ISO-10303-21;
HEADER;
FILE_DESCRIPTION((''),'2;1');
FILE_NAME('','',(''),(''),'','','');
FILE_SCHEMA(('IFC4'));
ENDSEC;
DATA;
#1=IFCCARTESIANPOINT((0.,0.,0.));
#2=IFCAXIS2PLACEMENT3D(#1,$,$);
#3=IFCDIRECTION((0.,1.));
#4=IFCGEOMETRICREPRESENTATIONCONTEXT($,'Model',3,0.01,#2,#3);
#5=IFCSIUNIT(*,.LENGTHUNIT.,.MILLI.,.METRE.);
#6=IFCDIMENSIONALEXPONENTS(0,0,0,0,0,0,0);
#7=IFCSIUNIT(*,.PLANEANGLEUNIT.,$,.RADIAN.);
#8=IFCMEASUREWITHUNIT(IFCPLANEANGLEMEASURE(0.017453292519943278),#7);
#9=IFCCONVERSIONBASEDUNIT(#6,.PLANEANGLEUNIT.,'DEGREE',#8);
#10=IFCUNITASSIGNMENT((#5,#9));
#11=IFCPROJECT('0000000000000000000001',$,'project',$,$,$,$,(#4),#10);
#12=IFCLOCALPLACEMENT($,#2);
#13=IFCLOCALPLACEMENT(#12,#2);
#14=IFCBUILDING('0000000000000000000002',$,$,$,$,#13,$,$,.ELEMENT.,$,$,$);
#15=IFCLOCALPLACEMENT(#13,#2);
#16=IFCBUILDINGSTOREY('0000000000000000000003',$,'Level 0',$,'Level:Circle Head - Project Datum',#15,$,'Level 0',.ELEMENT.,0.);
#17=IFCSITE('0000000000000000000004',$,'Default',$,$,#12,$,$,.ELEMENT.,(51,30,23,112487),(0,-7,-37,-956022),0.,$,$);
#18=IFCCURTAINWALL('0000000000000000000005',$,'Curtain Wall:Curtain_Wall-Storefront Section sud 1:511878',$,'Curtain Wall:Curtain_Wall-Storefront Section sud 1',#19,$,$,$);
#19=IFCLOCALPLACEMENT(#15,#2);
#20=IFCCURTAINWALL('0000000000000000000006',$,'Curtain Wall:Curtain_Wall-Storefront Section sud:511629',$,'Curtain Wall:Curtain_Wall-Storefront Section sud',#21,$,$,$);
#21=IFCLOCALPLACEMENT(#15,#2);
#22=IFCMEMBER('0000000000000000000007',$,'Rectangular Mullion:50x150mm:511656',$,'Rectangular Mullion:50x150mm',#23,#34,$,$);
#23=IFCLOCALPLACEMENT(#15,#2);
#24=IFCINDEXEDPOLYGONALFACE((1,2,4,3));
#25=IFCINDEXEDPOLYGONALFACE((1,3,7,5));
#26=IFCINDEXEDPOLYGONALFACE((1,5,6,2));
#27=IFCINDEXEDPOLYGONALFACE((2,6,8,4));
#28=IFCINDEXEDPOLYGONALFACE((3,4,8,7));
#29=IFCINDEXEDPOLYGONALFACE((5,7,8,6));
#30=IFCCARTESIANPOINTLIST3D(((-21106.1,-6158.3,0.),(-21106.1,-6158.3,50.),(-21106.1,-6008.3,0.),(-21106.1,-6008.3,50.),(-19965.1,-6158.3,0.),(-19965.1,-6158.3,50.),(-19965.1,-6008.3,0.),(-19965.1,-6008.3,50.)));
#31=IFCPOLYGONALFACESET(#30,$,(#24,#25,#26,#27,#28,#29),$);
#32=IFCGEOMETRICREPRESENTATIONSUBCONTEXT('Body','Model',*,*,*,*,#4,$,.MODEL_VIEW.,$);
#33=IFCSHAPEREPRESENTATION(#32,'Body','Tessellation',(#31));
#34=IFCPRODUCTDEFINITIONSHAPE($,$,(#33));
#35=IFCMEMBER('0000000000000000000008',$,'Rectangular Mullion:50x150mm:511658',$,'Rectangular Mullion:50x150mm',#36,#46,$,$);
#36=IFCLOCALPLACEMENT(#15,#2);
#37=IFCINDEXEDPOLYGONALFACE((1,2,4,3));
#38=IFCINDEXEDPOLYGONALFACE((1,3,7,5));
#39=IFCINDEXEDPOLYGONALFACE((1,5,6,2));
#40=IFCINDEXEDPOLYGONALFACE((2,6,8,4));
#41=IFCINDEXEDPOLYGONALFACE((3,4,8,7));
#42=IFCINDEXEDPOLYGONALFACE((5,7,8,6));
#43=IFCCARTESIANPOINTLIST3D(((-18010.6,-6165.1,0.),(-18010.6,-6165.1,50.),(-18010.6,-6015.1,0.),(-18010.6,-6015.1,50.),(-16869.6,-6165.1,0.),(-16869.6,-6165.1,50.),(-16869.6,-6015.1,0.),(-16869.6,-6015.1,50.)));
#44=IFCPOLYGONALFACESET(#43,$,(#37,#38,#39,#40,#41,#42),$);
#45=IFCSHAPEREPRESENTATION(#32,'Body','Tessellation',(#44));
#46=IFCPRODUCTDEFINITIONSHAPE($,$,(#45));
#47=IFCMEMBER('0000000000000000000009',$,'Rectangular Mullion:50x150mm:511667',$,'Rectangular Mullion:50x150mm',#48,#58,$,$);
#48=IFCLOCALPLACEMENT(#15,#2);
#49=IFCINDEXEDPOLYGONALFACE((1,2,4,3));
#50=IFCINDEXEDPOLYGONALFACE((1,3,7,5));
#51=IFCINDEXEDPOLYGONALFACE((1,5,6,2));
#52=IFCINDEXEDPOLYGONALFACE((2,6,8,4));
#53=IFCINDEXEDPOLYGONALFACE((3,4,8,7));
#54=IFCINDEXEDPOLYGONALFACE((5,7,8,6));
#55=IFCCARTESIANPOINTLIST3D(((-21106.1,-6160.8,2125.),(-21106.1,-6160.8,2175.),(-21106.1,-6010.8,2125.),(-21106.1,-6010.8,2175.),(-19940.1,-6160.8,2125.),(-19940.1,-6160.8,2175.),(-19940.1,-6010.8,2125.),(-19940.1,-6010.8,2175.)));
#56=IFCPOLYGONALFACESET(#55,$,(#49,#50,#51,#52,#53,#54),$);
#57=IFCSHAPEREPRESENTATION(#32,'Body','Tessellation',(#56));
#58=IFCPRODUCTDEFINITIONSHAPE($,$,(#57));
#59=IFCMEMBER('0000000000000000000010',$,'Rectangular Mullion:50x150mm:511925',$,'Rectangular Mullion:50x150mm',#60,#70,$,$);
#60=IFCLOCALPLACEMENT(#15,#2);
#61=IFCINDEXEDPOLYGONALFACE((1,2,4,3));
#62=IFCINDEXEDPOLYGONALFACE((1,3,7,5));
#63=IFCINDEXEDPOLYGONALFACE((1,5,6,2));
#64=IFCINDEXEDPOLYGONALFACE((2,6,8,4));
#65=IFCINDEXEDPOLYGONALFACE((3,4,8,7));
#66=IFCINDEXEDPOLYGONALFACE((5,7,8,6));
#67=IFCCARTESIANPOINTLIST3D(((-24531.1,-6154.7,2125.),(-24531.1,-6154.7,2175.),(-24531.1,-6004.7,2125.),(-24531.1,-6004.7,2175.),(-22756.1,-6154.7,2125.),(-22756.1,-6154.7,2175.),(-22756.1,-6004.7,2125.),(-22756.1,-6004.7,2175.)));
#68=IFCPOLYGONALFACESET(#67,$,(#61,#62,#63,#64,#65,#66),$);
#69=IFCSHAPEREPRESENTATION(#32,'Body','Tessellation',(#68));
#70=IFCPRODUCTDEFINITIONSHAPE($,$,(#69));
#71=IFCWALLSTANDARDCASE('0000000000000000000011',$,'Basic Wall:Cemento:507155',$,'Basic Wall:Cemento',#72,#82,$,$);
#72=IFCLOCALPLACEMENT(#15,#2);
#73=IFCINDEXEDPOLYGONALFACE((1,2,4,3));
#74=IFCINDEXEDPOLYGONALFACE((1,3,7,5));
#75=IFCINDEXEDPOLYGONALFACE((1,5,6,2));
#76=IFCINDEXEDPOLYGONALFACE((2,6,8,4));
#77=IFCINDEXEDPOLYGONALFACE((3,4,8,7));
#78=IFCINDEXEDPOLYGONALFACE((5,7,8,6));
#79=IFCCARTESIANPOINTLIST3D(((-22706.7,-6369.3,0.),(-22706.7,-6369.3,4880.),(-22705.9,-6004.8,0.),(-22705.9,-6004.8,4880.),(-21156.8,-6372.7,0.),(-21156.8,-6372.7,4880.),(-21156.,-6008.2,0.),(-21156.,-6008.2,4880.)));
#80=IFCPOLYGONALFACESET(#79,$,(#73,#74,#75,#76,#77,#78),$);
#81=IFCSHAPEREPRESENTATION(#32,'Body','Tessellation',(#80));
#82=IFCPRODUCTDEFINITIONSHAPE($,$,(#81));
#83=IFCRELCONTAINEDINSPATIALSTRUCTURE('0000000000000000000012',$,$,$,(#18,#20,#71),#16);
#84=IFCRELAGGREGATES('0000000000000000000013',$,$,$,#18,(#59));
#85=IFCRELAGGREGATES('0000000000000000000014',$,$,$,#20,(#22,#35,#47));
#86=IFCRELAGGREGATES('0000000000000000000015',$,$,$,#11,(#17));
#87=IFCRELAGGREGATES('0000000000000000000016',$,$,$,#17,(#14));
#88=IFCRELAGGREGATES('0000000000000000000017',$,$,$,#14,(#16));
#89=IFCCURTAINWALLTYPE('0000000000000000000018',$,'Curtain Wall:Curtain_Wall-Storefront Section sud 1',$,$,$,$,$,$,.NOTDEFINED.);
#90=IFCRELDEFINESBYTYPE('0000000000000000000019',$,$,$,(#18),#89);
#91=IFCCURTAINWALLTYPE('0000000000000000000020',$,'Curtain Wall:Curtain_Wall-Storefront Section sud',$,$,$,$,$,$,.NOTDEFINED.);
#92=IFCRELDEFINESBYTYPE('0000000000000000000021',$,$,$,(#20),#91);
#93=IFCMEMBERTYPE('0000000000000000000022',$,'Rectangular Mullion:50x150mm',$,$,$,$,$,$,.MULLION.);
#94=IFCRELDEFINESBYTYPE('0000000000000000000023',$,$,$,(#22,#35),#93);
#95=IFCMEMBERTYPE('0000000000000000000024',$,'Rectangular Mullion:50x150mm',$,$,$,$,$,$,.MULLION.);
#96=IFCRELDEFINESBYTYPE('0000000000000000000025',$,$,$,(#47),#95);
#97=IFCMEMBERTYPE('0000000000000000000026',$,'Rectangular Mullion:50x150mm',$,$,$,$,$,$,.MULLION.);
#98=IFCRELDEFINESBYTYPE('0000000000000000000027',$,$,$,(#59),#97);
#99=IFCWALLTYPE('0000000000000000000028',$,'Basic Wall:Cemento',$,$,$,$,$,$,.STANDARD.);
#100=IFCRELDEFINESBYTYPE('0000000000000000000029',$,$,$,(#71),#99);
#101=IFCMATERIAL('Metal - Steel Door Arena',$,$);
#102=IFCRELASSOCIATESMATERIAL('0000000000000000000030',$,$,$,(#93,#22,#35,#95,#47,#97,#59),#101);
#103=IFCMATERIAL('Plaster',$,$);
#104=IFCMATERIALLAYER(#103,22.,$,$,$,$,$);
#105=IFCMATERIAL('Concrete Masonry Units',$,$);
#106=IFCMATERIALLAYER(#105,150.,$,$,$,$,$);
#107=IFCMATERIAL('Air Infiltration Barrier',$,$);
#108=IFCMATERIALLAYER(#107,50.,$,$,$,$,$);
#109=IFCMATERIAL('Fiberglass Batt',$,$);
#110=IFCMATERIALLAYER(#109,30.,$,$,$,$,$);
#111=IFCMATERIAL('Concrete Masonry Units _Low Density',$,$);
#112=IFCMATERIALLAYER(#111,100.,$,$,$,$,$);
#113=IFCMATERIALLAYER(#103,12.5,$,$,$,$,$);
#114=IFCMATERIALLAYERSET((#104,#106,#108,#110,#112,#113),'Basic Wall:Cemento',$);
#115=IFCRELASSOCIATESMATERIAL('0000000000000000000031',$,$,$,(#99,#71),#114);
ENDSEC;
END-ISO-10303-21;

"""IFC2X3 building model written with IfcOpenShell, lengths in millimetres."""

from ifc_helpers import new_model, entity, si_unit, converted_unit, direction, frame, frame_2d, origin, origin_2d_with_axis, place, context, subcontext, project, spatial, rectangle, extrude, source, transform, mapped, material, layer, layer_set, layer_usage, type_object, type_shapes, element, aggregate, save


model = new_model("IFC2X3")

# Units and contexts
model_context = context("Model", 3, precision=0.01, world=origin(), true_north=direction((0.0, 1.0)))
body_context = subcontext(model_context, "Body", "Model", "MODEL_VIEW")
ifc_project = project(units=[si_unit("LENGTHUNIT", "METRE", prefix="MILLI"), converted_unit("PLANEANGLEUNIT", "DEGREE", entity("IfcPlaneAngleMeasure", 0.017453292519943278), si_unit("PLANEANGLEUNIT", "RADIAN"), dimensions=[0, 0, 0, 0, 0, 0, 0])], contexts=[model_context])

# Site, building, storey
site_placement = place(None, origin())
site = spatial("IfcSite", under=ifc_project, at=site_placement, Name="Default", CompositionType="ELEMENT", RefLatitude=(51, 30, 23, 112487), RefLongitude=(0, -7, -37, -956022), RefElevation=0.0)
building_placement = place(site_placement, origin())
building = spatial("IfcBuilding", under=site, at=building_placement, CompositionType="ELEMENT")
storey_placement = place(building_placement, origin())
storey = spatial("IfcBuildingStorey", under=building, at=storey_placement, Name="Level 0", ObjectType="Level:Circle Head - Project Datum", LongName="Level 0", CompositionType="ELEMENT", Elevation=0.0)

# Curtain wall
curtain_wall_type_1 = type_object("IfcCurtainWallType", Name="Curtain Wall:Curtain_Wall-Storefront Section sud 1", PredefinedType="NOTDEFINED")
curtain_wall_1_placement = place(storey_placement, origin())
curtain_wall_1 = element("IfcCurtainWall", 1, at=curtain_wall_1_placement, inside=storey, type_object=curtain_wall_type_1, Name="Curtain Wall:Curtain_Wall-Storefront Section sud 1:511878", ObjectType="Curtain Wall:Curtain_Wall-Storefront Section sud 1")
ifc_material_1 = material(Name="Metal - Steel Door Arena")

# Curtain wall
curtain_wall_type_2 = type_object("IfcCurtainWallType", Name="Curtain Wall:Curtain_Wall-Storefront Section sud", PredefinedType="NOTDEFINED")
curtain_wall_2_placement = place(storey_placement, origin())
curtain_wall_2 = element("IfcCurtainWall", 2, at=curtain_wall_2_placement, inside=storey, type_object=curtain_wall_type_2, Name="Curtain Wall:Curtain_Wall-Storefront Section sud:511629", ObjectType="Curtain Wall:Curtain_Wall-Storefront Section sud")

# Members
member_type_1 = type_object("IfcMemberType", Name="Rectangular Mullion:50x150mm", PredefinedType="MULLION", material=ifc_material_1)
shared_shape_1 = source(origin(), body_context, "Body", "SweptSolid", [
    extrude(rectangle(XDim=50.0, YDim=150.0, at=origin_2d_with_axis()), frame((-25.0, 0.0, -1141.0), z_axis=(0.0, 0.0, 1.0), x_axis=(-1.0, 0.0, 0.0)), (0.0, 0.0, 1.0), 1141.0),
])
type_shapes(member_type_1, [shared_shape_1])
member_1_placement = place(curtain_wall_2_placement, frame((-21106.1, -6083.3, 0.0), z_axis=(-1.0, 0.0, 0.0), x_axis=(0.0, 0.0, -1.0)))
member_1 = element("IfcMember", 3, at=member_1_placement, type_object=member_type_1, material=ifc_material_1, Name="Rectangular Mullion:50x150mm:511656", ObjectType="Rectangular Mullion:50x150mm", context=body_context, shape_type="MappedRepresentation", body=[
    mapped(shared_shape_1, transform((0.0, 0.0, 0.0), scale=1.0)),
])
member_2_placement = place(curtain_wall_2_placement, frame((-18010.6, -6090.1, 0.0), z_axis=(-1.0, 0.0, 0.0), x_axis=(0.0, 0.0, -1.0)))
member_2 = element("IfcMember", 4, at=member_2_placement, type_object=member_type_1, material=ifc_material_1, Name="Rectangular Mullion:50x150mm:511658", ObjectType="Rectangular Mullion:50x150mm", context=body_context, shape_type="MappedRepresentation", body=[
    mapped(shared_shape_1, transform((0.0, 0.0, 0.0), scale=1.0)),
])
member_type_2 = type_object("IfcMemberType", Name="Rectangular Mullion:50x150mm", PredefinedType="MULLION", material=ifc_material_1)
shared_shape_2 = source(origin(), body_context, "Body", "SweptSolid", [
    extrude(rectangle(XDim=50.0, YDim=150.0, at=origin_2d_with_axis()), frame((0.0, 0.0, -1166.0), z_axis=(0.0, 0.0, 1.0), x_axis=(-1.0, 0.0, 0.0)), (0.0, 0.0, 1.0), 1166.0),
])
type_shapes(member_type_2, [shared_shape_2])
member_3_placement = place(curtain_wall_2_placement, frame((-19940.1, -6085.8, 2150.0), z_axis=(1.0, 0.0, 0.0), x_axis=(0.0, 0.0, 1.0)))
member_3 = element("IfcMember", 5, at=member_3_placement, type_object=member_type_2, material=ifc_material_1, Name="Rectangular Mullion:50x150mm:511667", ObjectType="Rectangular Mullion:50x150mm", context=body_context, shape_type="MappedRepresentation", body=[
    mapped(shared_shape_2, transform((0.0, 0.0, 0.0), scale=1.0)),
])
member_type_3 = type_object("IfcMemberType", Name="Rectangular Mullion:50x150mm", PredefinedType="MULLION", material=ifc_material_1)
shared_shape_3 = source(origin(), body_context, "Body", "SweptSolid", [
    extrude(rectangle(XDim=50.0, YDim=150.0, at=origin_2d_with_axis()), frame((0.0, 0.0, -1775.0), z_axis=(0.0, 0.0, 1.0), x_axis=(-1.0, 0.0, 0.0)), (0.0, 0.0, 1.0), 1775.0),
])
type_shapes(member_type_3, [shared_shape_3])
member_4_placement = place(curtain_wall_1_placement, frame((-22756.1, -6079.7, 2150.0), z_axis=(1.0, 0.0, 0.0), x_axis=(0.0, 0.0, 1.0)))
member_4 = element("IfcMember", 6, at=member_4_placement, type_object=member_type_3, material=ifc_material_1, Name="Rectangular Mullion:50x150mm:511925", ObjectType="Rectangular Mullion:50x150mm", context=body_context, shape_type="MappedRepresentation", body=[
    mapped(shared_shape_3, transform((0.0, 0.0, 0.0), scale=1.0)),
])
aggregate(curtain_wall_1, [member_4])

aggregate(curtain_wall_2, [member_1, member_2, member_3])

# Wall
ifc_material_2 = material(Name="Plaster")
ifc_layer_1 = layer(ifc_material_2, 22.0)
ifc_material_3 = material(Name="Concrete Masonry Units")
ifc_layer_2 = layer(ifc_material_3, 150.0)
ifc_material_4 = material(Name="Air Infiltration Barrier")
ifc_layer_3 = layer(ifc_material_4, 50.0)
ifc_material_5 = material(Name="Fiberglass Batt")
ifc_layer_4 = layer(ifc_material_5, 30.0)
ifc_material_6 = material(Name="Concrete Masonry Units _Low Density")
ifc_layer_5 = layer(ifc_material_6, 100.0)
ifc_layer_6 = layer(ifc_material_2, 12.5)
ifc_layer_set = layer_set([ifc_layer_1, ifc_layer_2, ifc_layer_3, ifc_layer_4, ifc_layer_5, ifc_layer_6], Name="Basic Wall:Cemento")
ifc_layer_usage = layer_usage(ifc_layer_set, "AXIS2", "NEGATIVE", 182.3)
wall_type = type_object("IfcWallType", Name="Basic Wall:Cemento", PredefinedType="STANDARD", material=ifc_layer_set)
wall_placement = place(storey_placement, frame((-21156.4, -6190.4, 0.0), z_axis=(0.0, 0.0, 1.0), x_axis=(-0.999998, 0.002199, 0.0)))
element("IfcWallStandardCase", 7, at=wall_placement, inside=storey, type_object=wall_type, material=ifc_layer_usage, Name="Basic Wall:Cemento:507155", ObjectType="Basic Wall:Cemento", context=body_context, shape_type="SweptSolid", body=[
    extrude(rectangle(XDim=1550.0, YDim=364.5, at=frame_2d((775.0, 0.0), x_axis=(-1.0, 0.0))), origin(), (0.0, 0.0, 1.0), 4880.0),
])

save(model, "model.ifc")
